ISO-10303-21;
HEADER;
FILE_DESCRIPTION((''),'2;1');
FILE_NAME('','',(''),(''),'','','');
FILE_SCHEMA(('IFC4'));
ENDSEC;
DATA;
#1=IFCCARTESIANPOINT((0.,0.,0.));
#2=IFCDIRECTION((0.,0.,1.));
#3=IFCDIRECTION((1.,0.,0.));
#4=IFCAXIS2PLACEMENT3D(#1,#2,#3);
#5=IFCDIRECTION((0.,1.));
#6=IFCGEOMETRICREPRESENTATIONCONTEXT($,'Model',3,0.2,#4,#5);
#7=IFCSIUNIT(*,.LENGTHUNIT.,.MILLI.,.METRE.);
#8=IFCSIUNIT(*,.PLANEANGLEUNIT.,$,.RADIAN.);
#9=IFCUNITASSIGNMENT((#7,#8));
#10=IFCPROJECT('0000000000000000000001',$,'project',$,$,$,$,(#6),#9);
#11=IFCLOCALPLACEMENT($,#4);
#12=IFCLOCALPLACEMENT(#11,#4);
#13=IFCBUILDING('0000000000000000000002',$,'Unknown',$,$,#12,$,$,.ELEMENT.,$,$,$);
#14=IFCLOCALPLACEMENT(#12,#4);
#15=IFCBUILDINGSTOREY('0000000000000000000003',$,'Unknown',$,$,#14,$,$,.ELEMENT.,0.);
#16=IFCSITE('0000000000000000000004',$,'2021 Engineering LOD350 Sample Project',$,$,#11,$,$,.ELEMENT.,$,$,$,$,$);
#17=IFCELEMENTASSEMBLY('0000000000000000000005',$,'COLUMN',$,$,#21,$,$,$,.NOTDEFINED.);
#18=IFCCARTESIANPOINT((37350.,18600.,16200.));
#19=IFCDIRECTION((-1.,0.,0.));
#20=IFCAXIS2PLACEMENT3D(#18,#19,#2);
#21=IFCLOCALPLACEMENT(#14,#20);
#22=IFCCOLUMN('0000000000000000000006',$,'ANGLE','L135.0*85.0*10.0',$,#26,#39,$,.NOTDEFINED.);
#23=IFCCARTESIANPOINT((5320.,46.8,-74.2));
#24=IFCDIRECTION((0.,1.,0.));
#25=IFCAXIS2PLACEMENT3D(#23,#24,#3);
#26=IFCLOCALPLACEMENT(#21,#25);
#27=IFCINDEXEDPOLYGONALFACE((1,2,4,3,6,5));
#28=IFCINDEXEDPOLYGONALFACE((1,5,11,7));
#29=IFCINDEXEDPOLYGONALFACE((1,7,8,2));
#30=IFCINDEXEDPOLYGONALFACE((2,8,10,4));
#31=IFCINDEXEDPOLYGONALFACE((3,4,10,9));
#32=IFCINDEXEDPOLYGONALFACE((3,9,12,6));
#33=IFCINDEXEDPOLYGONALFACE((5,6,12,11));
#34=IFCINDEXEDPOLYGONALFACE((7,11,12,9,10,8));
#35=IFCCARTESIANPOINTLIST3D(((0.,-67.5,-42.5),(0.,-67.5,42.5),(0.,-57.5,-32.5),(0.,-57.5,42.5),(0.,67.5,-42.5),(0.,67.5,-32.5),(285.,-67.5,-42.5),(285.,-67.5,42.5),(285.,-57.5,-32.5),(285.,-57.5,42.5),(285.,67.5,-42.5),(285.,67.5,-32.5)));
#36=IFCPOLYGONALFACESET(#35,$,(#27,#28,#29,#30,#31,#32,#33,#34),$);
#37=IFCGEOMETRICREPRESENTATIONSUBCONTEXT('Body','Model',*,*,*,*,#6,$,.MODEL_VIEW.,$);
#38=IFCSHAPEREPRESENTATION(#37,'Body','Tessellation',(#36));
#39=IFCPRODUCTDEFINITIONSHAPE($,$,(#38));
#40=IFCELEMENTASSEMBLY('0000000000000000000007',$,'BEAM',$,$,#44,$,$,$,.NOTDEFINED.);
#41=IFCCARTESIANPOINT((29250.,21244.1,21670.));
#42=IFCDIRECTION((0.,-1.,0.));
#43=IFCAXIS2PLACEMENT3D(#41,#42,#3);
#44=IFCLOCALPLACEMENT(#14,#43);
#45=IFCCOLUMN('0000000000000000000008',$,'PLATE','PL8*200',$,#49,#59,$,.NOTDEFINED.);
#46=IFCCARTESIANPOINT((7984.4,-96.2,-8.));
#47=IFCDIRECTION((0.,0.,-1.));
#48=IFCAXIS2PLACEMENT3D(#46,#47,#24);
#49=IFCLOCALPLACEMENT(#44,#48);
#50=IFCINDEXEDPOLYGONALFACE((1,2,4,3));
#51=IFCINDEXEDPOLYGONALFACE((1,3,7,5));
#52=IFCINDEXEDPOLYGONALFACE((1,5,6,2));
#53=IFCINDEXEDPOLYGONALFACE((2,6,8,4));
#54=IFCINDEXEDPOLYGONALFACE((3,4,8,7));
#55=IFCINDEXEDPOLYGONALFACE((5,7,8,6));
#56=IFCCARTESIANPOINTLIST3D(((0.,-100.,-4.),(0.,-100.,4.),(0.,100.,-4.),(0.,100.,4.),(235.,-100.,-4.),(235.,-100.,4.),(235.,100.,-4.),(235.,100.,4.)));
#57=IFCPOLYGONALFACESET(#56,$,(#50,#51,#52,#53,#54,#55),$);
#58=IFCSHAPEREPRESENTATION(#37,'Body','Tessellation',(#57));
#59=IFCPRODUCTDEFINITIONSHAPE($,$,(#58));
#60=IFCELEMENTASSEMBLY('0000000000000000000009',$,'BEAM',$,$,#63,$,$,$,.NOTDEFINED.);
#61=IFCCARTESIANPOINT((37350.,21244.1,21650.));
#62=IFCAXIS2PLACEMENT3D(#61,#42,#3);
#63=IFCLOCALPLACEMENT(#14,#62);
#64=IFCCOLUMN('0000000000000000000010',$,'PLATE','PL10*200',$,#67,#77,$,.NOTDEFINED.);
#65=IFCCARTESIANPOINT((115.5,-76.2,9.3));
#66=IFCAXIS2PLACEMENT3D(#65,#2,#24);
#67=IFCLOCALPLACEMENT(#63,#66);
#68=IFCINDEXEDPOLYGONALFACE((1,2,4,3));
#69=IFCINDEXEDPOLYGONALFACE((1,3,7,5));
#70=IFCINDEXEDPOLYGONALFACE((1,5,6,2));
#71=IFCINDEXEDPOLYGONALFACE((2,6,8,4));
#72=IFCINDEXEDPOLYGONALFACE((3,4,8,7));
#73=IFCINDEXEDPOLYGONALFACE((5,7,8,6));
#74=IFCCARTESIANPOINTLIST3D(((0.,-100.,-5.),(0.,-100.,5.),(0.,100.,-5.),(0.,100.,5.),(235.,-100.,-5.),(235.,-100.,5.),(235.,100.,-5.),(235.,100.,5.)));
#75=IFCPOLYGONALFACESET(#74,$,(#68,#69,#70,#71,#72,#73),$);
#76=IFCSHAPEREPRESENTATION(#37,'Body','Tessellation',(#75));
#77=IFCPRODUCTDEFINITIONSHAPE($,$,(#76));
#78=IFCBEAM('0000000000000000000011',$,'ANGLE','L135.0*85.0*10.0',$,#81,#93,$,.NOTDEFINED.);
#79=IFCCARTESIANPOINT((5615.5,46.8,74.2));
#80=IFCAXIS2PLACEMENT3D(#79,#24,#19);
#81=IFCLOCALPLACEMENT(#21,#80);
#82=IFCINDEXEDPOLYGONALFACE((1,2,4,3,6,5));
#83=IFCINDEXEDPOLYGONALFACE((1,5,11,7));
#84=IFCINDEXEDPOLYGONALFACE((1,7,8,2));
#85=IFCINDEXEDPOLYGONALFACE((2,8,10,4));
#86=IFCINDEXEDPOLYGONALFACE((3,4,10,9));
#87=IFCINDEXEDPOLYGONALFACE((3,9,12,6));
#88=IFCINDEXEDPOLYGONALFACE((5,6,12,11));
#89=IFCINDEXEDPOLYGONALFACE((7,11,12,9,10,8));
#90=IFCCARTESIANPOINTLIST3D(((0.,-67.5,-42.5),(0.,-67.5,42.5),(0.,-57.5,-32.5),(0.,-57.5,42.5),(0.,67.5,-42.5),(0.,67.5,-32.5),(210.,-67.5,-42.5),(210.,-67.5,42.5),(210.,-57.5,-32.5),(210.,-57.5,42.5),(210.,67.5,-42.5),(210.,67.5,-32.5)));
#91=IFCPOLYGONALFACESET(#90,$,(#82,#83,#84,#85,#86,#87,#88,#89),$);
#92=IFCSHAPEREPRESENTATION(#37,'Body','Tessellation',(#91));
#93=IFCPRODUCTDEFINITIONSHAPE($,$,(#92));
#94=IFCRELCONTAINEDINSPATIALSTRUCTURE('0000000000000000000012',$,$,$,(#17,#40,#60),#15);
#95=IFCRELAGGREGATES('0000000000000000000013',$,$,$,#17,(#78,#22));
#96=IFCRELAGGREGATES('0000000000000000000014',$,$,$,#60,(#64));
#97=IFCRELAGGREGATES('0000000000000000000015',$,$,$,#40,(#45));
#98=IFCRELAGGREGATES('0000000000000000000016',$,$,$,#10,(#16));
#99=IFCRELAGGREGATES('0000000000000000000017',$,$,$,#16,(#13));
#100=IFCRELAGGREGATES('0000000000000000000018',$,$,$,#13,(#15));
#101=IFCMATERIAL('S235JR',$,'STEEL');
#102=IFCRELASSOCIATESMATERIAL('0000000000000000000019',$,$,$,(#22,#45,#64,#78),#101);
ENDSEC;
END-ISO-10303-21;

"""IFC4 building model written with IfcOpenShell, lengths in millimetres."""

from ifc_helpers import new_model, si_unit, direction, frame, origin_with_axes, place, context, subcontext, project, spatial, line, indexed_curve, outline, extrude, material, element, aggregate, save


model = new_model("IFC4")

# Units and contexts
model_context = context("Model", 3, precision=0.2, world=origin_with_axes(), true_north=direction((0.0, 1.0)))
body_context = subcontext(model_context, "Body", "Model", "MODEL_VIEW")
ifc_project = project(units=[si_unit("LENGTHUNIT", "METRE", prefix="MILLI"), si_unit("PLANEANGLEUNIT", "RADIAN")], contexts=[model_context])

# Site, building, storey
site_placement = place(None, origin_with_axes())
site = spatial("IfcSite", under=ifc_project, at=site_placement, Name="2021 Engineering LOD350 Sample Project", CompositionType="ELEMENT")
building_placement = place(site_placement, origin_with_axes())
building = spatial("IfcBuilding", under=site, at=building_placement, Name="Unknown", CompositionType="ELEMENT")
storey_placement = place(building_placement, origin_with_axes())
storey = spatial("IfcBuildingStorey", under=building, at=storey_placement, Name="Unknown", CompositionType="ELEMENT", Elevation=0.0)

# Element assemblies, columns
assembly_1_placement = place(storey_placement, frame((37350.0, 18600.0, 16200.0), z_axis=(-1.0, 0.0, 0.0), x_axis=(0.0, 0.0, 1.0)))
assembly_1 = element("IfcElementAssembly", 1, at=assembly_1_placement, inside=storey, Name="COLUMN", PredefinedType="NOTDEFINED")
ifc_material_1 = material(Name="S235JR", Category="STEEL")
column_1_placement = place(assembly_1_placement, frame((5320.0, 46.8, -74.2), z_axis=(0.0, 1.0, 0.0), x_axis=(1.0, 0.0, 0.0)))
column_1 = element("IfcColumn", 2, at=column_1_placement, material=ifc_material_1, Name="ANGLE", Description="L135.0*85.0*10.0", PredefinedType="NOTDEFINED", context=body_context, shape_type="SolidModel", body=[
    extrude(outline(indexed_curve([(-42.5, -67.5), (42.5, -67.5), (42.5, -57.5), (-32.5, -57.5), (-32.5, 67.5), (-42.5, 67.5)], segments=[line(1, 2, 3, 4, 5, 6, 1)])), frame((0.0, 0.0, 0.0), z_axis=(-1.0, 0.0, 0.0), x_axis=(0.0, 0.0, 1.0)), (0.0, 0.0, -1.0), 285.0),
])
assembly_2_placement = place(storey_placement, frame((29250.0, 21244.1, 21670.0), z_axis=(0.0, -1.0, 0.0), x_axis=(1.0, 0.0, 0.0)))
assembly_2 = element("IfcElementAssembly", 3, at=assembly_2_placement, inside=storey, Name="BEAM", PredefinedType="NOTDEFINED")
column_2_placement = place(assembly_2_placement, frame((7984.4, -96.2, -8.0), z_axis=(0.0, 0.0, -1.0), x_axis=(0.0, 1.0, 0.0)))
column_2 = element("IfcColumn", 4, at=column_2_placement, material=ifc_material_1, Name="PLATE", Description="PL8*200", PredefinedType="NOTDEFINED", context=body_context, shape_type="SolidModel", body=[
    extrude(outline(indexed_curve([(-4.0, -100.0), (4.0, -100.0), (4.0, 100.0), (-4.0, 100.0)], segments=[line(1, 2, 3, 4, 1)])), frame((0.0, 0.0, 0.0), z_axis=(-1.0, 0.0, 0.0), x_axis=(0.0, 0.0, 1.0)), (0.0, 0.0, -1.0), 235.0),
])

# Element assembly, column
assembly_3_placement = place(storey_placement, frame((37350.0, 21244.1, 21650.0), z_axis=(0.0, -1.0, 0.0), x_axis=(1.0, 0.0, 0.0)))
assembly_3 = element("IfcElementAssembly", 5, at=assembly_3_placement, inside=storey, Name="BEAM", PredefinedType="NOTDEFINED")
column_3_placement = place(assembly_3_placement, frame((115.5, -76.2, 9.3), z_axis=(0.0, 0.0, 1.0), x_axis=(0.0, 1.0, 0.0)))
column_3 = element("IfcColumn", 6, at=column_3_placement, material=ifc_material_1, Name="PLATE", Description="PL10*200", PredefinedType="NOTDEFINED", context=body_context, shape_type="SolidModel", body=[
    extrude(outline(indexed_curve([(-5.0, -100.0), (5.0, -100.0), (5.0, 100.0), (-5.0, 100.0)], segments=[line(1, 2, 3, 4, 1)])), frame((0.0, 0.0, 0.0), z_axis=(-1.0, 0.0, 0.0), x_axis=(0.0, 0.0, 1.0)), (0.0, 0.0, -1.0), 235.0),
])

# Beam
beam_placement = place(assembly_1_placement, frame((5615.5, 46.8, 74.2), z_axis=(0.0, 1.0, 0.0), x_axis=(-1.0, 0.0, 0.0)))
beam = element("IfcBeam", 7, at=beam_placement, material=ifc_material_1, Name="ANGLE", Description="L135.0*85.0*10.0", PredefinedType="NOTDEFINED", context=body_context, shape_type="SolidModel", body=[
    extrude(outline(indexed_curve([(-42.5, -67.5), (42.5, -67.5), (42.5, -57.5), (-32.5, -57.5), (-32.5, 67.5), (-42.5, 67.5)], segments=[line(1, 2, 3, 4, 5, 6, 1)])), frame((0.0, 0.0, 0.0), z_axis=(-1.0, 0.0, 0.0), x_axis=(0.0, 0.0, 1.0)), (0.0, 0.0, -1.0), 210.0),
])
aggregate(assembly_1, [beam, column_1])

aggregate(assembly_3, [column_3])
aggregate(assembly_2, [column_2])

save(model, "model.ifc")
